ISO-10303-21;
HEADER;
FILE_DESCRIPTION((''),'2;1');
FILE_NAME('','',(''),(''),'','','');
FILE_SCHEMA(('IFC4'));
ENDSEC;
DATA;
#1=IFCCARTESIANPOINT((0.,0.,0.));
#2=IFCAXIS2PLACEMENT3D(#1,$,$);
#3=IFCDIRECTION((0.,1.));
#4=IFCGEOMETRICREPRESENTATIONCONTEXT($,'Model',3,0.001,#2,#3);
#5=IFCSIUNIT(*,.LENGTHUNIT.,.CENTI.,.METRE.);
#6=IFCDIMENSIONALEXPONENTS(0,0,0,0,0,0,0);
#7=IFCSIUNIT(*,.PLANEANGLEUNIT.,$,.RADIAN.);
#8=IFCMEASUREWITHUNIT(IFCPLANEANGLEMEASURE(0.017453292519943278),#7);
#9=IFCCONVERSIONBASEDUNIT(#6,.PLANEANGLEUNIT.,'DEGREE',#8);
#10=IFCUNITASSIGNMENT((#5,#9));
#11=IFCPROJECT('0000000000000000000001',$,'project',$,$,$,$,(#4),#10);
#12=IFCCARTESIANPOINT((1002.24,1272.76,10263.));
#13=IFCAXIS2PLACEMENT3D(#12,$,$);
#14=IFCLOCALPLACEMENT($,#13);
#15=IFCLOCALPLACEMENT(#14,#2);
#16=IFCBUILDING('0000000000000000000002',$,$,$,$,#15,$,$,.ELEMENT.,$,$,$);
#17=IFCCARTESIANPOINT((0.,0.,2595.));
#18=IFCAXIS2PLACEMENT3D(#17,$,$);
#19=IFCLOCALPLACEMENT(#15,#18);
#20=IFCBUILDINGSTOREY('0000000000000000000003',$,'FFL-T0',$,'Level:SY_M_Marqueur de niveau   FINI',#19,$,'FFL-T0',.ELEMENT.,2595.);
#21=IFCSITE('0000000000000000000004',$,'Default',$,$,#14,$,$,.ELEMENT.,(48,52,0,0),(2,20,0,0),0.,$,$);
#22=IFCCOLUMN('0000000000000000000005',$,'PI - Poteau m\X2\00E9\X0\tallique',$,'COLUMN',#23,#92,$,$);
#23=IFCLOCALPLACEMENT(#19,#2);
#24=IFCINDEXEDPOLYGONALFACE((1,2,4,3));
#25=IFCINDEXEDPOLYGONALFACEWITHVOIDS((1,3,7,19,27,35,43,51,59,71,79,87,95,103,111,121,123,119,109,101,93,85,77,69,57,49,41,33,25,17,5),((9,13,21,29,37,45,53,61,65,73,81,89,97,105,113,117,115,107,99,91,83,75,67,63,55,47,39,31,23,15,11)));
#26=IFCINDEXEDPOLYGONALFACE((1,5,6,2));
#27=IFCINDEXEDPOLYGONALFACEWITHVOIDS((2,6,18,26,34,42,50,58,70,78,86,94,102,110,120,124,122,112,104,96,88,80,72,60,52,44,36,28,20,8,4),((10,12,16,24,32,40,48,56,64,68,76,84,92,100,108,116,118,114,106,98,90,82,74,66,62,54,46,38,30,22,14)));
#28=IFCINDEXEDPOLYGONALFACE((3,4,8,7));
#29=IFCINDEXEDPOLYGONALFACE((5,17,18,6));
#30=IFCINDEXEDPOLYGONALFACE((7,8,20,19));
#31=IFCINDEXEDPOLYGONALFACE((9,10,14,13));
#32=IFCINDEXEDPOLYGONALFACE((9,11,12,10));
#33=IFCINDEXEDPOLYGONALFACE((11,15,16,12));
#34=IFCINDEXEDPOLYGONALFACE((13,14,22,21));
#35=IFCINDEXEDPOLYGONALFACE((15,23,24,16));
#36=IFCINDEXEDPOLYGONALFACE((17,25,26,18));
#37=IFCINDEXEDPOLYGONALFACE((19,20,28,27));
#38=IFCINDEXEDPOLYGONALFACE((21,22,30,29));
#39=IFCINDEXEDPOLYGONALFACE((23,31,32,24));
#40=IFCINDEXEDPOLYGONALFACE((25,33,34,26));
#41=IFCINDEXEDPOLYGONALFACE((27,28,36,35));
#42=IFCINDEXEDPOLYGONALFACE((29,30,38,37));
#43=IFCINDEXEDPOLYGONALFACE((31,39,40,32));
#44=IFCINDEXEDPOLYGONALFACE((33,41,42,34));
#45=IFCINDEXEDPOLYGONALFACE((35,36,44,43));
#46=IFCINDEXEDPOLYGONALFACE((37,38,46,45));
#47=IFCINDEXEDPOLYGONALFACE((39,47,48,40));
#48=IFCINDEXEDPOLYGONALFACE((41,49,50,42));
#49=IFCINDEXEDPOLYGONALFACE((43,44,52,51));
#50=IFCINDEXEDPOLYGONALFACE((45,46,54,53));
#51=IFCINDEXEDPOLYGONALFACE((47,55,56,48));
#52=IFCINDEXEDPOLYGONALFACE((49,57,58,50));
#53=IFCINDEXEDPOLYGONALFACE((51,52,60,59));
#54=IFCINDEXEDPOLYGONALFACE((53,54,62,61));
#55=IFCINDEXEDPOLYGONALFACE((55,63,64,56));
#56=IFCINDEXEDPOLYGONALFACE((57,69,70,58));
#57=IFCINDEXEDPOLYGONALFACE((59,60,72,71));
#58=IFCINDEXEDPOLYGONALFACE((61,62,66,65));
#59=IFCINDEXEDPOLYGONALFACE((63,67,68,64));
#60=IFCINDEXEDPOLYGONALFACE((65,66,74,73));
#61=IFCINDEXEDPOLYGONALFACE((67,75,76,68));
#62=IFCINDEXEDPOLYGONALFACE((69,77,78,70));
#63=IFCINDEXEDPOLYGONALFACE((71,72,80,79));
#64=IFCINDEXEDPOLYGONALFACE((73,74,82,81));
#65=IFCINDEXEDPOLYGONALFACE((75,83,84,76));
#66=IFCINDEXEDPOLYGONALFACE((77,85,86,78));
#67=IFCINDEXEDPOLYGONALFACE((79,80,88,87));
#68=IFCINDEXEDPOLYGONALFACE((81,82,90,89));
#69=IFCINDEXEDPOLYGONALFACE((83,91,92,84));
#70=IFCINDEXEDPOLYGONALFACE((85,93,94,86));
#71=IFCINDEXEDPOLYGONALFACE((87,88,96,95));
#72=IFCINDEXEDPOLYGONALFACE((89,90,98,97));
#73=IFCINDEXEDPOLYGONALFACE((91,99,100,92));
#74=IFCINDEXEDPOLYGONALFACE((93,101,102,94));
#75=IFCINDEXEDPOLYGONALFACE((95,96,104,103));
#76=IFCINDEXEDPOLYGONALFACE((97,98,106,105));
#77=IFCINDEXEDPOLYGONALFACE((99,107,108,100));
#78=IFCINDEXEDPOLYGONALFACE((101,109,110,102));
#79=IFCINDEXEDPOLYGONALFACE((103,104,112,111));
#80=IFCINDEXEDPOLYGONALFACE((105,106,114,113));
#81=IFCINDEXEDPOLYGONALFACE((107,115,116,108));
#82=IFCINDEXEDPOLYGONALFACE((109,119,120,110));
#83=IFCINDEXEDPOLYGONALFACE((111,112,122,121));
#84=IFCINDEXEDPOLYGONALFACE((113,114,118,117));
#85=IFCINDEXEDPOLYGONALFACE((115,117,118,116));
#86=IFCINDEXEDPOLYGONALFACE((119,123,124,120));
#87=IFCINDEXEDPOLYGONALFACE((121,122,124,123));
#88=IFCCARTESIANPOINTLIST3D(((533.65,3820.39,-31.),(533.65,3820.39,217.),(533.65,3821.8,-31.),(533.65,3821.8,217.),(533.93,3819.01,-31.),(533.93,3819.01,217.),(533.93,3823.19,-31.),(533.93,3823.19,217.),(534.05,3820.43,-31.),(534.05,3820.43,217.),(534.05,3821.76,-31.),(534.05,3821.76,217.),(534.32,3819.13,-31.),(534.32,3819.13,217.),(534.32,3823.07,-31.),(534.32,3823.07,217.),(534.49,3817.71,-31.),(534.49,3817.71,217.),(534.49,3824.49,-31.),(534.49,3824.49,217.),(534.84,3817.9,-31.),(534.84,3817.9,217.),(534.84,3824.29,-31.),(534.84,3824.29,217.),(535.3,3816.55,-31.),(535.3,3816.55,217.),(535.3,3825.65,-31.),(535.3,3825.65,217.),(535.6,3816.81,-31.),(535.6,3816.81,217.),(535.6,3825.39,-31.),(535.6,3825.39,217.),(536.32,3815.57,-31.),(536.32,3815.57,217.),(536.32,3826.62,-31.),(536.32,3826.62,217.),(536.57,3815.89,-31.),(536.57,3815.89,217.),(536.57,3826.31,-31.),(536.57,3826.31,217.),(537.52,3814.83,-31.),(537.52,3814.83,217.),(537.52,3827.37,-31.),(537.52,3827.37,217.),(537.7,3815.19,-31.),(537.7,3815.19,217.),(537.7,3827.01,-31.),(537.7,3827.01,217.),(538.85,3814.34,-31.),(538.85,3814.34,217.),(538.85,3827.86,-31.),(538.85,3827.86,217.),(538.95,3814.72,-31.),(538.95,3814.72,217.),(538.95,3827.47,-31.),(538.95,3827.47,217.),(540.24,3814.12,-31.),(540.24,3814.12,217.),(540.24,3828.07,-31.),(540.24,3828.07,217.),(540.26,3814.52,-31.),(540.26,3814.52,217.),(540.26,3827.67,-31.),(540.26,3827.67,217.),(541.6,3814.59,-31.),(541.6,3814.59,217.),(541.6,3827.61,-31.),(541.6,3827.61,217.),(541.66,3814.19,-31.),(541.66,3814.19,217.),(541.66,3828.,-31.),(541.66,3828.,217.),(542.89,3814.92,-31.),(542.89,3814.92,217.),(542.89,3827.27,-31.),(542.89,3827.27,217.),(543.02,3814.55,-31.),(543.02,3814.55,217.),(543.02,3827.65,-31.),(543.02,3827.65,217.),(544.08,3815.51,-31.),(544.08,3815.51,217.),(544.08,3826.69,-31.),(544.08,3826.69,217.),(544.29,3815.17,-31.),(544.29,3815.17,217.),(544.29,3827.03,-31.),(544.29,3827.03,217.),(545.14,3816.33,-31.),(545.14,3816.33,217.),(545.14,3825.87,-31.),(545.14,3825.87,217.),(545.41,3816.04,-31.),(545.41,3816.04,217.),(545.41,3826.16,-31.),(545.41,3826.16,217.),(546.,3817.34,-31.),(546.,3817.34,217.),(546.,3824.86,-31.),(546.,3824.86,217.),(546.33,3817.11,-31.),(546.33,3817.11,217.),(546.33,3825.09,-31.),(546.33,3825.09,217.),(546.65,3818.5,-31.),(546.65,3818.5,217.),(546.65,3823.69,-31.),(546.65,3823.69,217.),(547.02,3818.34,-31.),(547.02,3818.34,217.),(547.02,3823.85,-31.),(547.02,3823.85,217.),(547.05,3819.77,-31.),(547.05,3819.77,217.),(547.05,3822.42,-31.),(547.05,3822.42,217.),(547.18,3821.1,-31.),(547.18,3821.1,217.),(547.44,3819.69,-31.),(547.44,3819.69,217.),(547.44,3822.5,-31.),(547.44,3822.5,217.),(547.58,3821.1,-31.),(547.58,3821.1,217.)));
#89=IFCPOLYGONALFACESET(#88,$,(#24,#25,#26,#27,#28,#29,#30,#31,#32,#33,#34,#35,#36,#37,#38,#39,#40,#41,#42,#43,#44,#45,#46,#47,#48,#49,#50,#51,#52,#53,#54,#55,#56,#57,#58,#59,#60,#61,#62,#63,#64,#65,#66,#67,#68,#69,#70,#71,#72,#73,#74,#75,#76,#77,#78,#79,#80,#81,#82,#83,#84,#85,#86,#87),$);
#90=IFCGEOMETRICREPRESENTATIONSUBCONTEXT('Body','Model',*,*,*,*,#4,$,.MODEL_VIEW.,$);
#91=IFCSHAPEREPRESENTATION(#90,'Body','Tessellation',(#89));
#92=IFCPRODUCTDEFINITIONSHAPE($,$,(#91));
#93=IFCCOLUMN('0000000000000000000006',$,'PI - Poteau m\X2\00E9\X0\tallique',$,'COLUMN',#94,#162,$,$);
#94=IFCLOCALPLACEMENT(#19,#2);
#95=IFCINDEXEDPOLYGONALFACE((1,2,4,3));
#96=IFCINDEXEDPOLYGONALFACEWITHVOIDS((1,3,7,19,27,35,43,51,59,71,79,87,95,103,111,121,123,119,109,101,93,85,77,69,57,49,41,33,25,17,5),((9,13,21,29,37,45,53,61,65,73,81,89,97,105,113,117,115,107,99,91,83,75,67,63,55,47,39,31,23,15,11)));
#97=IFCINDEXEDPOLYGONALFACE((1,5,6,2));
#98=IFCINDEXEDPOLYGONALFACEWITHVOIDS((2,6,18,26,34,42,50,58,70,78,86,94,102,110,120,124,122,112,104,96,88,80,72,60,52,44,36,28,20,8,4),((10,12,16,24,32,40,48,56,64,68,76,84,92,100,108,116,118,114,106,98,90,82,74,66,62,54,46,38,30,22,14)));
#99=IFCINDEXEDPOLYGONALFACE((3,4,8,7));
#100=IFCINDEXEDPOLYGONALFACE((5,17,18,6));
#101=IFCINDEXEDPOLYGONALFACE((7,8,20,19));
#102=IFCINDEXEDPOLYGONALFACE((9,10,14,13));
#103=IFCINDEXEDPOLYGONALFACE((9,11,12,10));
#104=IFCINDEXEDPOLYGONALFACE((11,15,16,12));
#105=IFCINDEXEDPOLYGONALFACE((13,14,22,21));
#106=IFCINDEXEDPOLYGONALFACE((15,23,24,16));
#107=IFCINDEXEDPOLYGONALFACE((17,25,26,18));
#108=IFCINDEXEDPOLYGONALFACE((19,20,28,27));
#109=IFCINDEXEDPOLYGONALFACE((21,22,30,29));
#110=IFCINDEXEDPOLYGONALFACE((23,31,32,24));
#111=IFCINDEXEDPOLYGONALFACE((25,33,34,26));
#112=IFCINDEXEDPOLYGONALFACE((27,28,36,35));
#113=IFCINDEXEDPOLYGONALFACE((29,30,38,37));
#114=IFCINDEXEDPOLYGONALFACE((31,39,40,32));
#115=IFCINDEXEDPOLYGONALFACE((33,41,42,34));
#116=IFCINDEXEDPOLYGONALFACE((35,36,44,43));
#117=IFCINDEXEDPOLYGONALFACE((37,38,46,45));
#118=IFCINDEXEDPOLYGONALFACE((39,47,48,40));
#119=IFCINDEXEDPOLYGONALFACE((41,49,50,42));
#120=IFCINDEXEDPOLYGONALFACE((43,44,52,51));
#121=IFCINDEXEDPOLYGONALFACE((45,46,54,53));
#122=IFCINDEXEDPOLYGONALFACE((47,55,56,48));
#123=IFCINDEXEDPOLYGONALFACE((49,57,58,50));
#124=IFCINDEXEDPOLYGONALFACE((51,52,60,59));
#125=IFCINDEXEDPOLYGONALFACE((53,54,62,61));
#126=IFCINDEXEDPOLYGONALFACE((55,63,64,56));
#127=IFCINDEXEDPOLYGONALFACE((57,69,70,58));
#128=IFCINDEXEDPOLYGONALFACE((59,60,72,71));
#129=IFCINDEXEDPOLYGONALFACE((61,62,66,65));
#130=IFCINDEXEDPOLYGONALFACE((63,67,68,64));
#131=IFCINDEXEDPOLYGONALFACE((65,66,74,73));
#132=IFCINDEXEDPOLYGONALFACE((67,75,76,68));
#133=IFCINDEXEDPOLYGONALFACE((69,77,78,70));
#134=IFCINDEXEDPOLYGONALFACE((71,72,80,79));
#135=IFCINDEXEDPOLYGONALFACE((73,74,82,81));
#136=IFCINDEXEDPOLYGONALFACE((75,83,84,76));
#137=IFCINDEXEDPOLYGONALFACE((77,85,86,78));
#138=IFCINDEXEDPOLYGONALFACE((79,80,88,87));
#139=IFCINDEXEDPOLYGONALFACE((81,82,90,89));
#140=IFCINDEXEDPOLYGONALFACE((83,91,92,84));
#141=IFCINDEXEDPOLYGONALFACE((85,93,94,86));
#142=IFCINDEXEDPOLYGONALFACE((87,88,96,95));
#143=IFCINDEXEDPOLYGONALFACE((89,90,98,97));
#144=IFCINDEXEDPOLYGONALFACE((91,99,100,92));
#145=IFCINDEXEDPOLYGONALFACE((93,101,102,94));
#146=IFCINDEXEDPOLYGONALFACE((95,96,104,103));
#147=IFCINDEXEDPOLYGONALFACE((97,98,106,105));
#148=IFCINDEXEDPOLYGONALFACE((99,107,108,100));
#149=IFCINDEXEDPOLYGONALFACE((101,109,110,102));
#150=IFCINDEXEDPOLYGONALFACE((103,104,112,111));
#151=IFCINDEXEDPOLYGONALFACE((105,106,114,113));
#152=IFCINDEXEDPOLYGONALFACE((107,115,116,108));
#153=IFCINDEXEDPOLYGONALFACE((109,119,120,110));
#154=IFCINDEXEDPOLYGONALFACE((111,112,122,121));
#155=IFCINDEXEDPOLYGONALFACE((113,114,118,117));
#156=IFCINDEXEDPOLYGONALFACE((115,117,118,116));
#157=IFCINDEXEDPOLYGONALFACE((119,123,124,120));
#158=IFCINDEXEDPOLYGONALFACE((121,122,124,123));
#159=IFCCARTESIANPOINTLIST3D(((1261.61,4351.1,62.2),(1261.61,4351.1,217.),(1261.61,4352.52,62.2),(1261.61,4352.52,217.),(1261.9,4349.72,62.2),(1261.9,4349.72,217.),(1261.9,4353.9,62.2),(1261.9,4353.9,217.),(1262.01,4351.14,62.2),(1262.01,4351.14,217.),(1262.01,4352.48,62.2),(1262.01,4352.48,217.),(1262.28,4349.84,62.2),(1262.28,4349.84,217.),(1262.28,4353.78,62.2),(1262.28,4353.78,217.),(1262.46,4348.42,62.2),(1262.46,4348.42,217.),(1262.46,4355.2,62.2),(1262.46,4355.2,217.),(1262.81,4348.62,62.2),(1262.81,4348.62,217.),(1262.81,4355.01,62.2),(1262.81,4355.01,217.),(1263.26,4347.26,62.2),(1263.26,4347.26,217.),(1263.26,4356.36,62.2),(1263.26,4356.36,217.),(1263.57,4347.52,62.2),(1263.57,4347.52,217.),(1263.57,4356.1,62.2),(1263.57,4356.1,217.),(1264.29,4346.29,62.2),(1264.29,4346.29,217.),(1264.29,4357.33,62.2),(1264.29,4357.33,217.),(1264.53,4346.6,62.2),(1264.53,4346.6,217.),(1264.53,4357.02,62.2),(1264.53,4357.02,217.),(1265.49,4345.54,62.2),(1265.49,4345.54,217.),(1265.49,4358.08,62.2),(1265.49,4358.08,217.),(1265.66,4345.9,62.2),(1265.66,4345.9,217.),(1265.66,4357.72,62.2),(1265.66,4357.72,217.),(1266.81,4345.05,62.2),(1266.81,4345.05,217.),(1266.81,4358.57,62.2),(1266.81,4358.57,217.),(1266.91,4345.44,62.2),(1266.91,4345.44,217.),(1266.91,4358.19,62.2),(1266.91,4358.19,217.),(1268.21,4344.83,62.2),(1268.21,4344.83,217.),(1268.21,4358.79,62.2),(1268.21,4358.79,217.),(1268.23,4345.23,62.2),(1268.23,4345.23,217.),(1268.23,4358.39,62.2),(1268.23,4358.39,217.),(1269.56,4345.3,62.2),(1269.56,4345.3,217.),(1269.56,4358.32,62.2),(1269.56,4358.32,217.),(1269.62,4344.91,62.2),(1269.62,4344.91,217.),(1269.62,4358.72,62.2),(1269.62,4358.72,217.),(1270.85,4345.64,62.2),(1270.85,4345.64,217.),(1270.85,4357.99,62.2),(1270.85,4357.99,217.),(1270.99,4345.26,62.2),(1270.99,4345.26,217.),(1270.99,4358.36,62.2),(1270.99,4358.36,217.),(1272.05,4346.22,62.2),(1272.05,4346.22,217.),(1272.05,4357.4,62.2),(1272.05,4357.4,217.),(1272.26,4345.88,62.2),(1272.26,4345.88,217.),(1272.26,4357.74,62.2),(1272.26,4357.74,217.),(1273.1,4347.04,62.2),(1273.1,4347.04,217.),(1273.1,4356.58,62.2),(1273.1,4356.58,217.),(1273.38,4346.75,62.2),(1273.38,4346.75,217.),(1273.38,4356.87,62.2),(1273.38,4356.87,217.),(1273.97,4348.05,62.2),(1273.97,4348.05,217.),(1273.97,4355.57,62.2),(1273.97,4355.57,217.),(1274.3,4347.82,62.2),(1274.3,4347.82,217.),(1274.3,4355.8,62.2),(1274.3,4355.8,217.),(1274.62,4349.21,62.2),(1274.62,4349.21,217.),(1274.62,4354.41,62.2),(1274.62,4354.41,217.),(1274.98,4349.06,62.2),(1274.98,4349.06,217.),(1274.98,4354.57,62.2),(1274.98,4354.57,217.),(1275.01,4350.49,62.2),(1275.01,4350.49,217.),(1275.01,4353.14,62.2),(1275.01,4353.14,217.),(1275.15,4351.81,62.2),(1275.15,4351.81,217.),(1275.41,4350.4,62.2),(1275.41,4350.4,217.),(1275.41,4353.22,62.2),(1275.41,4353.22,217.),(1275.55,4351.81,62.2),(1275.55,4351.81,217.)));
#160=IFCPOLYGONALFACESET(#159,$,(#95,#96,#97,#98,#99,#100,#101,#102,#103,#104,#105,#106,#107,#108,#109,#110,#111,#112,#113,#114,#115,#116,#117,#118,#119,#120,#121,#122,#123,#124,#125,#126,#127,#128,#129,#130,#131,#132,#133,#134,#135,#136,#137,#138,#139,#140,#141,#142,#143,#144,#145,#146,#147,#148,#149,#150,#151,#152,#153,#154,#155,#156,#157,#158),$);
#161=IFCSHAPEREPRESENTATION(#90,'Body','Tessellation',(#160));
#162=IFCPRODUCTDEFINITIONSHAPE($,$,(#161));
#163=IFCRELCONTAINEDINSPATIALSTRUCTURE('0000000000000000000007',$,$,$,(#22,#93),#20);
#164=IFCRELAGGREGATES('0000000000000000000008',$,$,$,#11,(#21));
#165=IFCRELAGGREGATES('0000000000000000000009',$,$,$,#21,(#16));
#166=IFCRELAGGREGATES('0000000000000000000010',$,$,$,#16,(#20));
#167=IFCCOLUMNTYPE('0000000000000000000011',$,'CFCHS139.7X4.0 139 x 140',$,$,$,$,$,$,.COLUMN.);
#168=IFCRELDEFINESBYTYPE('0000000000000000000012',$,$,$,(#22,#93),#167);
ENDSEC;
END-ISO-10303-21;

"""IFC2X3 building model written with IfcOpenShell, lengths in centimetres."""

from ifc_helpers import new_model, entity, si_unit, converted_unit, direction, frame, origin, place, context, subcontext, project, spatial, polyline, outline, extrude, type_object, element, save


model = new_model("IFC2X3")

# Units and contexts
model_context = context("Model", 3, precision=0.001, world=origin(), true_north=direction((0.0, 1.0)))
body_context = subcontext(model_context, "Body", "Model", "MODEL_VIEW")
ifc_project = project(units=[si_unit("LENGTHUNIT", "METRE", prefix="CENTI"), converted_unit("PLANEANGLEUNIT", "DEGREE", entity("IfcPlaneAngleMeasure", 0.017453292519943278), si_unit("PLANEANGLEUNIT", "RADIAN"), dimensions=[0, 0, 0, 0, 0, 0, 0])], contexts=[model_context])

# Site, building, storey
site_placement = place(None, frame((1002.24, 1272.76, 10263.0)))
site = spatial("IfcSite", under=ifc_project, at=site_placement, Name="Default", CompositionType="ELEMENT", RefLatitude=(48, 52, 0, 0), RefLongitude=(2, 20, 0, 0), RefElevation=0.0)
building_placement = place(site_placement, origin())
building = spatial("IfcBuilding", under=site, at=building_placement, CompositionType="ELEMENT")
storey_placement = place(building_placement, frame((0.0, 0.0, 2595.0)))
storey = spatial("IfcBuildingStorey", under=building, at=storey_placement, Name="FFL-T0", ObjectType="Level:SY_M_Marqueur de niveau   FINI", LongName="FFL-T0", CompositionType="ELEMENT", Elevation=2595.0)

# Columns
column_type = type_object("IfcColumnType", Name="CFCHS139.7X4.0 139 x 140", PredefinedType="COLUMN")
column_1_placement = place(storey_placement, origin())
element("IfcColumn", 1, at=column_1_placement, inside=storey, type_object=column_type, Name="PI - Poteau métallique", ObjectType="COLUMN", context=body_context, shape_type="SweptSolid", body=[
    extrude(outline(polyline([(-0.71, -6.95), (0.71, -6.95), (2.09, -6.66), (3.39, -6.11), (4.55, -5.3), (5.52, -4.28), (6.27, -3.08), (6.76, -1.75), (6.98, -0.35), (6.9, 1.06), (6.55, 2.43), (5.93, 3.69), (5.06, 4.81), (3.99, 5.73), (2.75, 6.42), (1.41, 6.84), (0.0, 6.98), (-1.41, 6.84), (-2.75, 6.42), (-3.99, 5.73), (-5.06, 4.81), (-5.93, 3.69), (-6.55, 2.43), (-6.9, 1.06), (-6.98, -0.35), (-6.76, -1.75), (-6.27, -3.08), (-5.52, -4.28), (-4.55, -5.3), (-3.39, -6.11), (-2.09, -6.66), (-0.71, -6.95)]), holes=[polyline([(-5.21, -4.03), (-5.91, -2.9), (-6.37, -1.65), (-6.58, -0.33), (-6.51, 1.0), (-6.18, 2.29), (-5.59, 3.48), (-4.77, 4.54), (-3.76, 5.4), (-2.6, 6.05), (-1.33, 6.45), (0.0, 6.58), (1.33, 6.45), (2.6, 6.05), (3.76, 5.4), (4.77, 4.54), (5.59, 3.48), (6.18, 2.29), (6.51, 1.0), (6.58, -0.33), (6.37, -1.65), (5.91, -2.9), (5.21, -4.03), (4.29, -5.0), (3.2, -5.76), (1.97, -6.28), (0.67, -6.55), (-0.67, -6.55), (-1.97, -6.28), (-3.2, -5.76), (-4.29, -5.0), (-5.21, -4.03)])]), frame((540.6, 3821.1, -31.0), z_axis=(0.0, 0.0, 1.0), x_axis=(-0.485302, 0.874347, 0.0)), (0.0, 0.0, 1.0), 248.0),
])
column_2_placement = place(storey_placement, origin())
element("IfcColumn", 2, at=column_2_placement, inside=storey, type_object=column_type, Name="PI - Poteau métallique", ObjectType="COLUMN", context=body_context, shape_type="SweptSolid", body=[
    extrude(outline(polyline([(-0.71, -6.95), (0.71, -6.95), (2.09, -6.66), (3.39, -6.11), (4.55, -5.3), (5.52, -4.28), (6.27, -3.08), (6.76, -1.75), (6.98, -0.35), (6.9, 1.06), (6.55, 2.43), (5.93, 3.69), (5.06, 4.81), (3.99, 5.73), (2.75, 6.42), (1.41, 6.84), (0.0, 6.98), (-1.41, 6.84), (-2.75, 6.42), (-3.99, 5.73), (-5.06, 4.81), (-5.93, 3.69), (-6.55, 2.43), (-6.9, 1.06), (-6.98, -0.35), (-6.76, -1.75), (-6.27, -3.08), (-5.52, -4.28), (-4.55, -5.3), (-3.39, -6.11), (-2.09, -6.66), (-0.71, -6.95)]), holes=[polyline([(-5.21, -4.03), (-5.91, -2.9), (-6.37, -1.65), (-6.58, -0.33), (-6.51, 1.0), (-6.18, 2.29), (-5.59, 3.48), (-4.77, 4.54), (-3.76, 5.4), (-2.6, 6.05), (-1.33, 6.45), (0.0, 6.58), (1.33, 6.45), (2.6, 6.05), (3.76, 5.4), (4.77, 4.54), (5.59, 3.48), (6.18, 2.29), (6.51, 1.0), (6.58, -0.33), (6.37, -1.65), (5.91, -2.9), (5.21, -4.03), (4.29, -5.0), (3.2, -5.76), (1.97, -6.28), (0.67, -6.55), (-0.67, -6.55), (-1.97, -6.28), (-3.2, -5.76), (-4.29, -5.0), (-5.21, -4.03)])]), frame((1268.56, 4351.81, 62.2), z_axis=(0.0, 0.0, 1.0), x_axis=(-0.485302, 0.874347, 0.0)), (0.0, 0.0, 1.0), 154.8),
])

save(model, "model.ifc")
